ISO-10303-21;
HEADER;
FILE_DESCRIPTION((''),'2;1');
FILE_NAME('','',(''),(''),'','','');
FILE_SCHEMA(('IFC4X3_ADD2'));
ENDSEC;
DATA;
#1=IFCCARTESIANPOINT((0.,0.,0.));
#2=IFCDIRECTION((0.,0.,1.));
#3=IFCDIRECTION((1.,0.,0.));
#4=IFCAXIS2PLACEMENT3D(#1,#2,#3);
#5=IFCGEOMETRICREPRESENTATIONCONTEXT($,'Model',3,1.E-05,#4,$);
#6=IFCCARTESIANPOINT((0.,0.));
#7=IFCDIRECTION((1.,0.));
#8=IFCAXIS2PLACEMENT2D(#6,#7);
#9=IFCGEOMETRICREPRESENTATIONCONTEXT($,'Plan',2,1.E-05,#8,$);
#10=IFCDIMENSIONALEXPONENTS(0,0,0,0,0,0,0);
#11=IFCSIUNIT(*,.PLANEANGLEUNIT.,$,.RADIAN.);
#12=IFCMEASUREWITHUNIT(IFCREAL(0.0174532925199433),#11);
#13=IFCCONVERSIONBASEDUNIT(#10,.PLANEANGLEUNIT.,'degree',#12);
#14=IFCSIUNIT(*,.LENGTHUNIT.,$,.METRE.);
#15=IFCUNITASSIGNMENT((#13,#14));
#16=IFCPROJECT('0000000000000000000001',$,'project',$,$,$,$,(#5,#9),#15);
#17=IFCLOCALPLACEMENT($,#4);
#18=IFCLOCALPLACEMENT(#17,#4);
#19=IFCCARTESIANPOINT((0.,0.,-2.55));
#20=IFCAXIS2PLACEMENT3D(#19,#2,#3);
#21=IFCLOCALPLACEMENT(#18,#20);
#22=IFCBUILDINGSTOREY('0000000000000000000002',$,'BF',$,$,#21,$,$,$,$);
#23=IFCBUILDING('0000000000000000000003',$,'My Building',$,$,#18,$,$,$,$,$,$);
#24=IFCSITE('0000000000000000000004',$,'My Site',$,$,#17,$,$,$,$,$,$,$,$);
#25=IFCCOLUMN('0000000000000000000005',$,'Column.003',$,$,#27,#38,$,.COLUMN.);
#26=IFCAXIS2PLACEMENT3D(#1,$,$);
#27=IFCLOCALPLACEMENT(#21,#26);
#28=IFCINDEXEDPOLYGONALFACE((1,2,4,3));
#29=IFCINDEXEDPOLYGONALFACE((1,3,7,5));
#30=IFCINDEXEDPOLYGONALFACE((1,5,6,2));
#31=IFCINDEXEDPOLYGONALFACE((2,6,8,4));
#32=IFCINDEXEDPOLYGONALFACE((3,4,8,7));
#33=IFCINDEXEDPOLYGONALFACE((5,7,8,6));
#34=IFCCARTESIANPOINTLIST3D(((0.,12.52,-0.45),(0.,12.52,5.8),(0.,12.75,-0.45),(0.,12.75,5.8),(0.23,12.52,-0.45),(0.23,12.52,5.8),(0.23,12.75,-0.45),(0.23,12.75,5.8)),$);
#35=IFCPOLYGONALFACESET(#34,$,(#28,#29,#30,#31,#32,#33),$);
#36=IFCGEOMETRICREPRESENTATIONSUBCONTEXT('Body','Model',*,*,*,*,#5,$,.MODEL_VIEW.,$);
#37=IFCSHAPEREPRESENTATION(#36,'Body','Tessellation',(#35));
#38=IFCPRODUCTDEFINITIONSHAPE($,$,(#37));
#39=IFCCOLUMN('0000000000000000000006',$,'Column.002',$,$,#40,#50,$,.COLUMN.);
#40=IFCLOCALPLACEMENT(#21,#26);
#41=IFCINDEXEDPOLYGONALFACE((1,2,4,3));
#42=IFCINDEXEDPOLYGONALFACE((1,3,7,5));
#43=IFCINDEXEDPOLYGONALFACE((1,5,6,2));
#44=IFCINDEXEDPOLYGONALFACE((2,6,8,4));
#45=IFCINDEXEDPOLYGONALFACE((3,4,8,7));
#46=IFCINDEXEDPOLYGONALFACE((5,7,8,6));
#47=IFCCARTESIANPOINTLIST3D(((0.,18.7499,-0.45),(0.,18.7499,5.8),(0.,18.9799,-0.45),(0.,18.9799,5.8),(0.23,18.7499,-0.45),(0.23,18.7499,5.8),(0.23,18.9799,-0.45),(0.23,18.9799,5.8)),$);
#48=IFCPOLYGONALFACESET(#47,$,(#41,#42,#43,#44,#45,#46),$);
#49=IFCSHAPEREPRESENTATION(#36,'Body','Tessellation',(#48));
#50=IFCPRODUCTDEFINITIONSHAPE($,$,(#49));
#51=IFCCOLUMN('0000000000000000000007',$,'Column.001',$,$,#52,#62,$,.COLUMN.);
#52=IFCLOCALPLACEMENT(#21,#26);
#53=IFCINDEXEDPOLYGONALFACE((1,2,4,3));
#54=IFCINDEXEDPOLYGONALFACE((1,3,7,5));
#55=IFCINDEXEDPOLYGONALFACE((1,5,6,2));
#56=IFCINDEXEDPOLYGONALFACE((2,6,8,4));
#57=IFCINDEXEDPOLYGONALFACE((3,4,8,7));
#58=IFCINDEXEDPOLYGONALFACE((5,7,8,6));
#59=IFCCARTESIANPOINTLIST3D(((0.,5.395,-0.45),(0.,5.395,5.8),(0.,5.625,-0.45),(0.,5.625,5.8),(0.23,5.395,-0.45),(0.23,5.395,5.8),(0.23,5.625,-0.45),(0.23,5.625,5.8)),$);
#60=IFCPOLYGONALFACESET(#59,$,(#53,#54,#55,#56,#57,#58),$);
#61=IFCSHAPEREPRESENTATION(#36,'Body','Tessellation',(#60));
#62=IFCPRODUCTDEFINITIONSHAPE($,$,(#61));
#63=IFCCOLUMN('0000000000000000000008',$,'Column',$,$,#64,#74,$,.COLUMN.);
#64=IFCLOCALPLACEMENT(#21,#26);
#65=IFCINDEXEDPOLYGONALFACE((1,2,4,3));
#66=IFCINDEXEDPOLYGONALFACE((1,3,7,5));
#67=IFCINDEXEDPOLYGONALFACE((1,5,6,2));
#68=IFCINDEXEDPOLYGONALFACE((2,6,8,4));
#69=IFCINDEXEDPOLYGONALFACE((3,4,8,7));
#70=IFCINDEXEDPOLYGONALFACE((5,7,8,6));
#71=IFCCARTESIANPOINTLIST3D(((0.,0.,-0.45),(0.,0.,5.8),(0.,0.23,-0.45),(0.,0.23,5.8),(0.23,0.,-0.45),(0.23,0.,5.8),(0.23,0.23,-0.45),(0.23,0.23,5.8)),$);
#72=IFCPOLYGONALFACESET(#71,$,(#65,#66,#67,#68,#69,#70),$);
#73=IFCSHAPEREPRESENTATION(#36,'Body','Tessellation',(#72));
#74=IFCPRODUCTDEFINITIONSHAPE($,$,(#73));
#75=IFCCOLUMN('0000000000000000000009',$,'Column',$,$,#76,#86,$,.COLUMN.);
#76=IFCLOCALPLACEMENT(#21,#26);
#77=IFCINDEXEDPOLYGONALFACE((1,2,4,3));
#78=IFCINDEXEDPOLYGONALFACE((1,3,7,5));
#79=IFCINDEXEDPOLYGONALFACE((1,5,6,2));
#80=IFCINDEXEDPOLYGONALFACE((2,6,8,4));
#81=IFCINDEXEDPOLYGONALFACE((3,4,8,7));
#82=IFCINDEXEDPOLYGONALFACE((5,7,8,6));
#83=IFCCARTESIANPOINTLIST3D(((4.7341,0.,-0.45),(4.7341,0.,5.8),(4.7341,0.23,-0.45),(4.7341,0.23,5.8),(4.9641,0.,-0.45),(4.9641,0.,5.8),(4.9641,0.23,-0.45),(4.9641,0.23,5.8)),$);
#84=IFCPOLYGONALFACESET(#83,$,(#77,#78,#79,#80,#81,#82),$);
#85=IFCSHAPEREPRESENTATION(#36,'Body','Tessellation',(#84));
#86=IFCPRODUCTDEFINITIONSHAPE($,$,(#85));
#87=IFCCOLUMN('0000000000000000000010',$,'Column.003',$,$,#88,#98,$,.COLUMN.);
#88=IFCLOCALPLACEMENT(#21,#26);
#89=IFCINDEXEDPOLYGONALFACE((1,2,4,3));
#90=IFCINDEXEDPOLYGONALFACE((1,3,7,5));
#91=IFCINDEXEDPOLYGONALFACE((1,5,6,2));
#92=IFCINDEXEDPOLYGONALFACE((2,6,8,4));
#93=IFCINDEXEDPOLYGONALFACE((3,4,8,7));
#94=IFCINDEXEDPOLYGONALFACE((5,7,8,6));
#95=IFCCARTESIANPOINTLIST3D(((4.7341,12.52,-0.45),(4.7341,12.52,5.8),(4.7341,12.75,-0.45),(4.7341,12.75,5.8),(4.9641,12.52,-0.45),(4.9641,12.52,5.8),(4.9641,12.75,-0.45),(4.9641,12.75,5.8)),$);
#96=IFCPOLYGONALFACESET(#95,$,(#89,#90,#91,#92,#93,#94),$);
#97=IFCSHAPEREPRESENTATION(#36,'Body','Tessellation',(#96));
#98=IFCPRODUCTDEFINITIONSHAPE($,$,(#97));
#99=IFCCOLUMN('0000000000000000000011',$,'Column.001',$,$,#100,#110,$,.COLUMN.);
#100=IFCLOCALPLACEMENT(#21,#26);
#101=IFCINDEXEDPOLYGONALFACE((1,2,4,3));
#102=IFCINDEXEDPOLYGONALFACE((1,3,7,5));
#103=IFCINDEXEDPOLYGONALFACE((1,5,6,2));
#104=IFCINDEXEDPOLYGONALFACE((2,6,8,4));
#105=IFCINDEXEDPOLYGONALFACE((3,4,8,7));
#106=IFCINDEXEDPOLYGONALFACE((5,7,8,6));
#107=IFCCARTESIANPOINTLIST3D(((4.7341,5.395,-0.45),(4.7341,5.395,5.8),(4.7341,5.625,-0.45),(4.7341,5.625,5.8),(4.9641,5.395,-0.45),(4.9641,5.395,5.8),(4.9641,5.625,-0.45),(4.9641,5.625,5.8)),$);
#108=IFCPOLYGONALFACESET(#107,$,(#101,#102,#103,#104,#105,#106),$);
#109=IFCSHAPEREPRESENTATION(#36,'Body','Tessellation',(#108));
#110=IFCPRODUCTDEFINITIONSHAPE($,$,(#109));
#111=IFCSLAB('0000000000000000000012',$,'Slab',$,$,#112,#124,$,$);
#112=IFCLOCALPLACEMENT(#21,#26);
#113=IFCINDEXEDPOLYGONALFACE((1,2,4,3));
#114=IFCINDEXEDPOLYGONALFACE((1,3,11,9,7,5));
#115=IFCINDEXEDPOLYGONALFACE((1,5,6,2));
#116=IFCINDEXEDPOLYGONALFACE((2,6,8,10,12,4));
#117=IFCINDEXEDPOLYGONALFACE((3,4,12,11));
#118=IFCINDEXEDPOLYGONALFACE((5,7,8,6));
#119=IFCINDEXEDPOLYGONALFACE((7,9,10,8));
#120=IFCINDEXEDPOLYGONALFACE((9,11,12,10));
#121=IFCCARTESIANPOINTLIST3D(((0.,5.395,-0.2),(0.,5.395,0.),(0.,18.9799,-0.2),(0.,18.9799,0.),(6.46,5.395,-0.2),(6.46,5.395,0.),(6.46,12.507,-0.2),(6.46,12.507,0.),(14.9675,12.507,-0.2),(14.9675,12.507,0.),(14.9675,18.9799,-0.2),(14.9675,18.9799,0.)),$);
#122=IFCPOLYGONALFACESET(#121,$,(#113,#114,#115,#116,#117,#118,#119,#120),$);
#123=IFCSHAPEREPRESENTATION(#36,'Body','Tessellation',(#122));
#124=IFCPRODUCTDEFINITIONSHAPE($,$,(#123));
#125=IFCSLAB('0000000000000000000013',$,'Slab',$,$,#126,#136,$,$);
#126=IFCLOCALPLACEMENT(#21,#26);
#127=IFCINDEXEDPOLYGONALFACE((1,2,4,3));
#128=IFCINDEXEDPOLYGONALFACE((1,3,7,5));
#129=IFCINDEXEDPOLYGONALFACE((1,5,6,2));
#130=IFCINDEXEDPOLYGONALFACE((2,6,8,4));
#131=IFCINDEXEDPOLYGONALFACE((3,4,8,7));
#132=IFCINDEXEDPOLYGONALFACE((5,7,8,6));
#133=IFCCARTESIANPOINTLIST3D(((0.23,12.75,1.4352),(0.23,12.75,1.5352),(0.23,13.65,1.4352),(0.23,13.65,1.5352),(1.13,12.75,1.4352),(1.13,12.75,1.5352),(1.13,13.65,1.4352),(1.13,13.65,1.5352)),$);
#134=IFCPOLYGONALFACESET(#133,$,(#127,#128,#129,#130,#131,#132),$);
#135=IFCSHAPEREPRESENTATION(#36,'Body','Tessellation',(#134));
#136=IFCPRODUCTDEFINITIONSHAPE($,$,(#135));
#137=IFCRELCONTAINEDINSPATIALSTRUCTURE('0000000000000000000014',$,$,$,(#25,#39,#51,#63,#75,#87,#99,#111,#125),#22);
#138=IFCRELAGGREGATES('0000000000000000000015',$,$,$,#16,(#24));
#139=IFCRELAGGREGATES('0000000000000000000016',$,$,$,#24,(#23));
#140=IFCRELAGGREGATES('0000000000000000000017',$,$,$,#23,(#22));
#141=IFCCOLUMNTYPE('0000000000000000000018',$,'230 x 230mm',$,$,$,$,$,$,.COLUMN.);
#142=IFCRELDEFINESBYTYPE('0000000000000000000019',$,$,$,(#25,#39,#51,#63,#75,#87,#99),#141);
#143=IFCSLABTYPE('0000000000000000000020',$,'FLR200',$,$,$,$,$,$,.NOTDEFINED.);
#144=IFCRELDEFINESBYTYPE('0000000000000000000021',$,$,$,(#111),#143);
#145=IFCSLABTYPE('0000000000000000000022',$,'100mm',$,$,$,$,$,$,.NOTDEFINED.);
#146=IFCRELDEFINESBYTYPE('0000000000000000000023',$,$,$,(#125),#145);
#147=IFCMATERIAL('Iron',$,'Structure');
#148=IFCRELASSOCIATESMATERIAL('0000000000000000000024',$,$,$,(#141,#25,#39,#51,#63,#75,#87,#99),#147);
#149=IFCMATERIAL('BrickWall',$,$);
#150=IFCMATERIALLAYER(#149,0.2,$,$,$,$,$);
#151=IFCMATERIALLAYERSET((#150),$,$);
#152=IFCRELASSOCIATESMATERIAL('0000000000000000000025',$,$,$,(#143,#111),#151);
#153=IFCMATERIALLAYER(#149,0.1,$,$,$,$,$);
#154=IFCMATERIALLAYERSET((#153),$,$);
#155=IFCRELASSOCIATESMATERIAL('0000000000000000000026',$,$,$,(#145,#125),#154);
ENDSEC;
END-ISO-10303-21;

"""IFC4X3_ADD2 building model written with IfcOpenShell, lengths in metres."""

from ifc_helpers import new_model, entity, si_unit, converted_unit, frame, origin_with_axes, origin_2d_with_axis, place, context, subcontext, project, spatial, line, indexed_curve, rectangle, outline, extrude, material, layer, layer_set, layer_usage, material_profile, profile_set, profile_usage, type_object, element, save


model = new_model("IFC4X3_ADD2")

# Units and contexts
model_context = context("Model", 3, precision=1e-05, world=origin_with_axes())
plan_context = context("Plan", 2, precision=1e-05, world=origin_2d_with_axis())
body_context_1 = subcontext(model_context, "Body", "Model", "MODEL_VIEW")
ifc_project = project(units=[converted_unit("PLANEANGLEUNIT", "degree", entity("IfcReal", 0.0174532925199433), si_unit("PLANEANGLEUNIT", "RADIAN"), dimensions=[0, 0, 0, 0, 0, 0, 0]), si_unit("LENGTHUNIT", "METRE")], contexts=[model_context, plan_context])

# Site, building, storey
site_placement = place(None, origin_with_axes())
site = spatial("IfcSite", under=ifc_project, at=site_placement, Name="My Site")
building_placement = place(site_placement, origin_with_axes())
building = spatial("IfcBuilding", under=site, at=building_placement, Name="My Building")
storey_placement = place(building_placement, frame((0.0, 0.0, -2.55), z_axis=(0.0, 0.0, 1.0), x_axis=(1.0, 0.0, 0.0)))
storey = spatial("IfcBuildingStorey", under=building, at=storey_placement, Name="BF")

# Columns
ifc_material_1 = material(Name="Iron", Category="Structure")
ifc_material_profile = material_profile(ifc_material_1, rectangle(XDim=0.23, YDim=0.23))
ifc_profile_set = profile_set([ifc_material_profile])
ifc_profile_usage_1 = profile_usage(ifc_profile_set)
column_type = type_object("IfcColumnType", Name="230 x 230mm", PredefinedType="COLUMN", material=ifc_profile_set)
column_1_placement = place(storey_placement, frame((0.115, 12.635, -0.45), z_axis=(0.0, 0.0, 1.0), x_axis=(1.0, 0.0, 0.0)))
element("IfcColumn", 1, at=column_1_placement, inside=storey, type_object=column_type, material=ifc_profile_usage_1, Name="Column.003", PredefinedType="COLUMN", context=body_context_1, shape_type="SweptSolid", body=[
    extrude(rectangle(XDim=0.23, YDim=0.23), origin_with_axes(), (0.0, 0.0, 1.0), 6.25),
])
ifc_profile_usage_2 = profile_usage(ifc_profile_set)
column_2_placement = place(storey_placement, frame((0.115, 18.8649, -0.45), z_axis=(0.0, 0.0, 1.0), x_axis=(1.0, 0.0, 0.0)))
element("IfcColumn", 2, at=column_2_placement, inside=storey, type_object=column_type, material=ifc_profile_usage_2, Name="Column.002", PredefinedType="COLUMN", context=body_context_1, shape_type="SweptSolid", body=[
    extrude(rectangle(XDim=0.23, YDim=0.23), origin_with_axes(), (0.0, 0.0, 1.0), 6.25),
])
ifc_profile_usage_3 = profile_usage(ifc_profile_set)
column_3_placement = place(storey_placement, frame((0.115, 5.51, -0.45), z_axis=(0.0, 0.0, 1.0), x_axis=(1.0, 0.0, 0.0)))
element("IfcColumn", 3, at=column_3_placement, inside=storey, type_object=column_type, material=ifc_profile_usage_3, Name="Column.001", PredefinedType="COLUMN", context=body_context_1, shape_type="SweptSolid", body=[
    extrude(rectangle(XDim=0.23, YDim=0.23), origin_with_axes(), (0.0, 0.0, 1.0), 6.25),
])
ifc_profile_usage_4 = profile_usage(ifc_profile_set)
column_4_placement = place(storey_placement, frame((0.115, 0.115, -0.45), z_axis=(0.0, 0.0, 1.0), x_axis=(1.0, 0.0, 0.0)))
element("IfcColumn", 4, at=column_4_placement, inside=storey, type_object=column_type, material=ifc_profile_usage_4, Name="Column", PredefinedType="COLUMN", context=body_context_1, shape_type="SweptSolid", body=[
    extrude(rectangle(XDim=0.23, YDim=0.23), origin_with_axes(), (0.0, 0.0, 1.0), 6.25),
])
ifc_profile_usage_5 = profile_usage(ifc_profile_set)
column_5_placement = place(storey_placement, frame((4.8491, 0.115, -0.45), z_axis=(0.0, 0.0, 1.0), x_axis=(1.0, 0.0, 0.0)))
element("IfcColumn", 5, at=column_5_placement, inside=storey, type_object=column_type, material=ifc_profile_usage_5, Name="Column", PredefinedType="COLUMN", context=body_context_1, shape_type="SweptSolid", body=[
    extrude(rectangle(XDim=0.23, YDim=0.23), origin_with_axes(), (0.0, 0.0, 1.0), 6.25),
])
ifc_profile_usage_6 = profile_usage(ifc_profile_set)
column_6_placement = place(storey_placement, frame((4.8491, 12.635, -0.45), z_axis=(0.0, 0.0, 1.0), x_axis=(1.0, 0.0, 0.0)))
element("IfcColumn", 6, at=column_6_placement, inside=storey, type_object=column_type, material=ifc_profile_usage_6, Name="Column.003", PredefinedType="COLUMN", context=body_context_1, shape_type="SweptSolid", body=[
    extrude(rectangle(XDim=0.23, YDim=0.23), origin_with_axes(), (0.0, 0.0, 1.0), 6.25),
])
ifc_profile_usage_7 = profile_usage(ifc_profile_set)
column_7_placement = place(storey_placement, frame((4.8491, 5.51, -0.45), z_axis=(0.0, 0.0, 1.0), x_axis=(1.0, 0.0, 0.0)))
element("IfcColumn", 7, at=column_7_placement, inside=storey, type_object=column_type, material=ifc_profile_usage_7, Name="Column.001", PredefinedType="COLUMN", context=body_context_1, shape_type="SweptSolid", body=[
    extrude(rectangle(XDim=0.23, YDim=0.23), origin_with_axes(), (0.0, 0.0, 1.0), 6.25),
])

# Slabs
ifc_material_2 = material(Name="BrickWall")
ifc_layer_1 = layer(ifc_material_2, 0.2)
ifc_layer_set_1 = layer_set([ifc_layer_1])
ifc_layer_usage_1 = layer_usage(ifc_layer_set_1, "AXIS3", "POSITIVE", 0.0)
slab_type_1 = type_object("IfcSlabType", Name="FLR200", PredefinedType="NOTDEFINED", material=ifc_layer_set_1)
slab_1_placement = place(storey_placement, frame((0.0, 5.395, -0.2), z_axis=(0.0, 0.0, 1.0), x_axis=(1.0, 0.0, 0.0)))
element("IfcSlab", 8, at=slab_1_placement, inside=storey, type_object=slab_type_1, material=ifc_layer_usage_1, Name="Slab", context=body_context_1, shape_type="SweptSolid", body=[
    extrude(outline(indexed_curve([(6.46, 0.0), (6.46, 7.112), (14.9675, 7.112), (14.9675, 13.5849), (0.0, 13.5849), (0.0, 0.0)], segments=[line(1, 6), line(6, 5), line(5, 4), line(4, 3), line(3, 2), line(2, 1)], self_intersect=False)), None, (0.0, 0.0, 1.0), 0.2),
])
ifc_layer_2 = layer(ifc_material_2, 0.1)
ifc_layer_set_2 = layer_set([ifc_layer_2])
slab_type_2 = type_object("IfcSlabType", Name="100mm", PredefinedType="NOTDEFINED", material=ifc_layer_set_2)
ifc_layer_usage_2 = layer_usage(ifc_layer_set_2, "AXIS3", "POSITIVE", 0.0)
slab_2_placement = place(storey_placement, frame((1.13, 13.75, 1.4352), z_axis=(0.0, 0.0, 1.0), x_axis=(-1.0, 0.0, 0.0)))
element("IfcSlab", 9, at=slab_2_placement, inside=storey, type_object=slab_type_2, material=ifc_layer_usage_2, Name="Slab", context=body_context_1, shape_type="SweptSolid", body=[
    extrude(outline(indexed_curve([(0.0, 1.0), (0.9, 1.0), (0.9, 0.1), (0.0, 0.1)], segments=[line(4, 1), line(1, 2), line(2, 3), line(3, 4)], self_intersect=False)), None, (0.0, 0.0, 1.0), 0.1),
])

save(model, "model.ifc")
